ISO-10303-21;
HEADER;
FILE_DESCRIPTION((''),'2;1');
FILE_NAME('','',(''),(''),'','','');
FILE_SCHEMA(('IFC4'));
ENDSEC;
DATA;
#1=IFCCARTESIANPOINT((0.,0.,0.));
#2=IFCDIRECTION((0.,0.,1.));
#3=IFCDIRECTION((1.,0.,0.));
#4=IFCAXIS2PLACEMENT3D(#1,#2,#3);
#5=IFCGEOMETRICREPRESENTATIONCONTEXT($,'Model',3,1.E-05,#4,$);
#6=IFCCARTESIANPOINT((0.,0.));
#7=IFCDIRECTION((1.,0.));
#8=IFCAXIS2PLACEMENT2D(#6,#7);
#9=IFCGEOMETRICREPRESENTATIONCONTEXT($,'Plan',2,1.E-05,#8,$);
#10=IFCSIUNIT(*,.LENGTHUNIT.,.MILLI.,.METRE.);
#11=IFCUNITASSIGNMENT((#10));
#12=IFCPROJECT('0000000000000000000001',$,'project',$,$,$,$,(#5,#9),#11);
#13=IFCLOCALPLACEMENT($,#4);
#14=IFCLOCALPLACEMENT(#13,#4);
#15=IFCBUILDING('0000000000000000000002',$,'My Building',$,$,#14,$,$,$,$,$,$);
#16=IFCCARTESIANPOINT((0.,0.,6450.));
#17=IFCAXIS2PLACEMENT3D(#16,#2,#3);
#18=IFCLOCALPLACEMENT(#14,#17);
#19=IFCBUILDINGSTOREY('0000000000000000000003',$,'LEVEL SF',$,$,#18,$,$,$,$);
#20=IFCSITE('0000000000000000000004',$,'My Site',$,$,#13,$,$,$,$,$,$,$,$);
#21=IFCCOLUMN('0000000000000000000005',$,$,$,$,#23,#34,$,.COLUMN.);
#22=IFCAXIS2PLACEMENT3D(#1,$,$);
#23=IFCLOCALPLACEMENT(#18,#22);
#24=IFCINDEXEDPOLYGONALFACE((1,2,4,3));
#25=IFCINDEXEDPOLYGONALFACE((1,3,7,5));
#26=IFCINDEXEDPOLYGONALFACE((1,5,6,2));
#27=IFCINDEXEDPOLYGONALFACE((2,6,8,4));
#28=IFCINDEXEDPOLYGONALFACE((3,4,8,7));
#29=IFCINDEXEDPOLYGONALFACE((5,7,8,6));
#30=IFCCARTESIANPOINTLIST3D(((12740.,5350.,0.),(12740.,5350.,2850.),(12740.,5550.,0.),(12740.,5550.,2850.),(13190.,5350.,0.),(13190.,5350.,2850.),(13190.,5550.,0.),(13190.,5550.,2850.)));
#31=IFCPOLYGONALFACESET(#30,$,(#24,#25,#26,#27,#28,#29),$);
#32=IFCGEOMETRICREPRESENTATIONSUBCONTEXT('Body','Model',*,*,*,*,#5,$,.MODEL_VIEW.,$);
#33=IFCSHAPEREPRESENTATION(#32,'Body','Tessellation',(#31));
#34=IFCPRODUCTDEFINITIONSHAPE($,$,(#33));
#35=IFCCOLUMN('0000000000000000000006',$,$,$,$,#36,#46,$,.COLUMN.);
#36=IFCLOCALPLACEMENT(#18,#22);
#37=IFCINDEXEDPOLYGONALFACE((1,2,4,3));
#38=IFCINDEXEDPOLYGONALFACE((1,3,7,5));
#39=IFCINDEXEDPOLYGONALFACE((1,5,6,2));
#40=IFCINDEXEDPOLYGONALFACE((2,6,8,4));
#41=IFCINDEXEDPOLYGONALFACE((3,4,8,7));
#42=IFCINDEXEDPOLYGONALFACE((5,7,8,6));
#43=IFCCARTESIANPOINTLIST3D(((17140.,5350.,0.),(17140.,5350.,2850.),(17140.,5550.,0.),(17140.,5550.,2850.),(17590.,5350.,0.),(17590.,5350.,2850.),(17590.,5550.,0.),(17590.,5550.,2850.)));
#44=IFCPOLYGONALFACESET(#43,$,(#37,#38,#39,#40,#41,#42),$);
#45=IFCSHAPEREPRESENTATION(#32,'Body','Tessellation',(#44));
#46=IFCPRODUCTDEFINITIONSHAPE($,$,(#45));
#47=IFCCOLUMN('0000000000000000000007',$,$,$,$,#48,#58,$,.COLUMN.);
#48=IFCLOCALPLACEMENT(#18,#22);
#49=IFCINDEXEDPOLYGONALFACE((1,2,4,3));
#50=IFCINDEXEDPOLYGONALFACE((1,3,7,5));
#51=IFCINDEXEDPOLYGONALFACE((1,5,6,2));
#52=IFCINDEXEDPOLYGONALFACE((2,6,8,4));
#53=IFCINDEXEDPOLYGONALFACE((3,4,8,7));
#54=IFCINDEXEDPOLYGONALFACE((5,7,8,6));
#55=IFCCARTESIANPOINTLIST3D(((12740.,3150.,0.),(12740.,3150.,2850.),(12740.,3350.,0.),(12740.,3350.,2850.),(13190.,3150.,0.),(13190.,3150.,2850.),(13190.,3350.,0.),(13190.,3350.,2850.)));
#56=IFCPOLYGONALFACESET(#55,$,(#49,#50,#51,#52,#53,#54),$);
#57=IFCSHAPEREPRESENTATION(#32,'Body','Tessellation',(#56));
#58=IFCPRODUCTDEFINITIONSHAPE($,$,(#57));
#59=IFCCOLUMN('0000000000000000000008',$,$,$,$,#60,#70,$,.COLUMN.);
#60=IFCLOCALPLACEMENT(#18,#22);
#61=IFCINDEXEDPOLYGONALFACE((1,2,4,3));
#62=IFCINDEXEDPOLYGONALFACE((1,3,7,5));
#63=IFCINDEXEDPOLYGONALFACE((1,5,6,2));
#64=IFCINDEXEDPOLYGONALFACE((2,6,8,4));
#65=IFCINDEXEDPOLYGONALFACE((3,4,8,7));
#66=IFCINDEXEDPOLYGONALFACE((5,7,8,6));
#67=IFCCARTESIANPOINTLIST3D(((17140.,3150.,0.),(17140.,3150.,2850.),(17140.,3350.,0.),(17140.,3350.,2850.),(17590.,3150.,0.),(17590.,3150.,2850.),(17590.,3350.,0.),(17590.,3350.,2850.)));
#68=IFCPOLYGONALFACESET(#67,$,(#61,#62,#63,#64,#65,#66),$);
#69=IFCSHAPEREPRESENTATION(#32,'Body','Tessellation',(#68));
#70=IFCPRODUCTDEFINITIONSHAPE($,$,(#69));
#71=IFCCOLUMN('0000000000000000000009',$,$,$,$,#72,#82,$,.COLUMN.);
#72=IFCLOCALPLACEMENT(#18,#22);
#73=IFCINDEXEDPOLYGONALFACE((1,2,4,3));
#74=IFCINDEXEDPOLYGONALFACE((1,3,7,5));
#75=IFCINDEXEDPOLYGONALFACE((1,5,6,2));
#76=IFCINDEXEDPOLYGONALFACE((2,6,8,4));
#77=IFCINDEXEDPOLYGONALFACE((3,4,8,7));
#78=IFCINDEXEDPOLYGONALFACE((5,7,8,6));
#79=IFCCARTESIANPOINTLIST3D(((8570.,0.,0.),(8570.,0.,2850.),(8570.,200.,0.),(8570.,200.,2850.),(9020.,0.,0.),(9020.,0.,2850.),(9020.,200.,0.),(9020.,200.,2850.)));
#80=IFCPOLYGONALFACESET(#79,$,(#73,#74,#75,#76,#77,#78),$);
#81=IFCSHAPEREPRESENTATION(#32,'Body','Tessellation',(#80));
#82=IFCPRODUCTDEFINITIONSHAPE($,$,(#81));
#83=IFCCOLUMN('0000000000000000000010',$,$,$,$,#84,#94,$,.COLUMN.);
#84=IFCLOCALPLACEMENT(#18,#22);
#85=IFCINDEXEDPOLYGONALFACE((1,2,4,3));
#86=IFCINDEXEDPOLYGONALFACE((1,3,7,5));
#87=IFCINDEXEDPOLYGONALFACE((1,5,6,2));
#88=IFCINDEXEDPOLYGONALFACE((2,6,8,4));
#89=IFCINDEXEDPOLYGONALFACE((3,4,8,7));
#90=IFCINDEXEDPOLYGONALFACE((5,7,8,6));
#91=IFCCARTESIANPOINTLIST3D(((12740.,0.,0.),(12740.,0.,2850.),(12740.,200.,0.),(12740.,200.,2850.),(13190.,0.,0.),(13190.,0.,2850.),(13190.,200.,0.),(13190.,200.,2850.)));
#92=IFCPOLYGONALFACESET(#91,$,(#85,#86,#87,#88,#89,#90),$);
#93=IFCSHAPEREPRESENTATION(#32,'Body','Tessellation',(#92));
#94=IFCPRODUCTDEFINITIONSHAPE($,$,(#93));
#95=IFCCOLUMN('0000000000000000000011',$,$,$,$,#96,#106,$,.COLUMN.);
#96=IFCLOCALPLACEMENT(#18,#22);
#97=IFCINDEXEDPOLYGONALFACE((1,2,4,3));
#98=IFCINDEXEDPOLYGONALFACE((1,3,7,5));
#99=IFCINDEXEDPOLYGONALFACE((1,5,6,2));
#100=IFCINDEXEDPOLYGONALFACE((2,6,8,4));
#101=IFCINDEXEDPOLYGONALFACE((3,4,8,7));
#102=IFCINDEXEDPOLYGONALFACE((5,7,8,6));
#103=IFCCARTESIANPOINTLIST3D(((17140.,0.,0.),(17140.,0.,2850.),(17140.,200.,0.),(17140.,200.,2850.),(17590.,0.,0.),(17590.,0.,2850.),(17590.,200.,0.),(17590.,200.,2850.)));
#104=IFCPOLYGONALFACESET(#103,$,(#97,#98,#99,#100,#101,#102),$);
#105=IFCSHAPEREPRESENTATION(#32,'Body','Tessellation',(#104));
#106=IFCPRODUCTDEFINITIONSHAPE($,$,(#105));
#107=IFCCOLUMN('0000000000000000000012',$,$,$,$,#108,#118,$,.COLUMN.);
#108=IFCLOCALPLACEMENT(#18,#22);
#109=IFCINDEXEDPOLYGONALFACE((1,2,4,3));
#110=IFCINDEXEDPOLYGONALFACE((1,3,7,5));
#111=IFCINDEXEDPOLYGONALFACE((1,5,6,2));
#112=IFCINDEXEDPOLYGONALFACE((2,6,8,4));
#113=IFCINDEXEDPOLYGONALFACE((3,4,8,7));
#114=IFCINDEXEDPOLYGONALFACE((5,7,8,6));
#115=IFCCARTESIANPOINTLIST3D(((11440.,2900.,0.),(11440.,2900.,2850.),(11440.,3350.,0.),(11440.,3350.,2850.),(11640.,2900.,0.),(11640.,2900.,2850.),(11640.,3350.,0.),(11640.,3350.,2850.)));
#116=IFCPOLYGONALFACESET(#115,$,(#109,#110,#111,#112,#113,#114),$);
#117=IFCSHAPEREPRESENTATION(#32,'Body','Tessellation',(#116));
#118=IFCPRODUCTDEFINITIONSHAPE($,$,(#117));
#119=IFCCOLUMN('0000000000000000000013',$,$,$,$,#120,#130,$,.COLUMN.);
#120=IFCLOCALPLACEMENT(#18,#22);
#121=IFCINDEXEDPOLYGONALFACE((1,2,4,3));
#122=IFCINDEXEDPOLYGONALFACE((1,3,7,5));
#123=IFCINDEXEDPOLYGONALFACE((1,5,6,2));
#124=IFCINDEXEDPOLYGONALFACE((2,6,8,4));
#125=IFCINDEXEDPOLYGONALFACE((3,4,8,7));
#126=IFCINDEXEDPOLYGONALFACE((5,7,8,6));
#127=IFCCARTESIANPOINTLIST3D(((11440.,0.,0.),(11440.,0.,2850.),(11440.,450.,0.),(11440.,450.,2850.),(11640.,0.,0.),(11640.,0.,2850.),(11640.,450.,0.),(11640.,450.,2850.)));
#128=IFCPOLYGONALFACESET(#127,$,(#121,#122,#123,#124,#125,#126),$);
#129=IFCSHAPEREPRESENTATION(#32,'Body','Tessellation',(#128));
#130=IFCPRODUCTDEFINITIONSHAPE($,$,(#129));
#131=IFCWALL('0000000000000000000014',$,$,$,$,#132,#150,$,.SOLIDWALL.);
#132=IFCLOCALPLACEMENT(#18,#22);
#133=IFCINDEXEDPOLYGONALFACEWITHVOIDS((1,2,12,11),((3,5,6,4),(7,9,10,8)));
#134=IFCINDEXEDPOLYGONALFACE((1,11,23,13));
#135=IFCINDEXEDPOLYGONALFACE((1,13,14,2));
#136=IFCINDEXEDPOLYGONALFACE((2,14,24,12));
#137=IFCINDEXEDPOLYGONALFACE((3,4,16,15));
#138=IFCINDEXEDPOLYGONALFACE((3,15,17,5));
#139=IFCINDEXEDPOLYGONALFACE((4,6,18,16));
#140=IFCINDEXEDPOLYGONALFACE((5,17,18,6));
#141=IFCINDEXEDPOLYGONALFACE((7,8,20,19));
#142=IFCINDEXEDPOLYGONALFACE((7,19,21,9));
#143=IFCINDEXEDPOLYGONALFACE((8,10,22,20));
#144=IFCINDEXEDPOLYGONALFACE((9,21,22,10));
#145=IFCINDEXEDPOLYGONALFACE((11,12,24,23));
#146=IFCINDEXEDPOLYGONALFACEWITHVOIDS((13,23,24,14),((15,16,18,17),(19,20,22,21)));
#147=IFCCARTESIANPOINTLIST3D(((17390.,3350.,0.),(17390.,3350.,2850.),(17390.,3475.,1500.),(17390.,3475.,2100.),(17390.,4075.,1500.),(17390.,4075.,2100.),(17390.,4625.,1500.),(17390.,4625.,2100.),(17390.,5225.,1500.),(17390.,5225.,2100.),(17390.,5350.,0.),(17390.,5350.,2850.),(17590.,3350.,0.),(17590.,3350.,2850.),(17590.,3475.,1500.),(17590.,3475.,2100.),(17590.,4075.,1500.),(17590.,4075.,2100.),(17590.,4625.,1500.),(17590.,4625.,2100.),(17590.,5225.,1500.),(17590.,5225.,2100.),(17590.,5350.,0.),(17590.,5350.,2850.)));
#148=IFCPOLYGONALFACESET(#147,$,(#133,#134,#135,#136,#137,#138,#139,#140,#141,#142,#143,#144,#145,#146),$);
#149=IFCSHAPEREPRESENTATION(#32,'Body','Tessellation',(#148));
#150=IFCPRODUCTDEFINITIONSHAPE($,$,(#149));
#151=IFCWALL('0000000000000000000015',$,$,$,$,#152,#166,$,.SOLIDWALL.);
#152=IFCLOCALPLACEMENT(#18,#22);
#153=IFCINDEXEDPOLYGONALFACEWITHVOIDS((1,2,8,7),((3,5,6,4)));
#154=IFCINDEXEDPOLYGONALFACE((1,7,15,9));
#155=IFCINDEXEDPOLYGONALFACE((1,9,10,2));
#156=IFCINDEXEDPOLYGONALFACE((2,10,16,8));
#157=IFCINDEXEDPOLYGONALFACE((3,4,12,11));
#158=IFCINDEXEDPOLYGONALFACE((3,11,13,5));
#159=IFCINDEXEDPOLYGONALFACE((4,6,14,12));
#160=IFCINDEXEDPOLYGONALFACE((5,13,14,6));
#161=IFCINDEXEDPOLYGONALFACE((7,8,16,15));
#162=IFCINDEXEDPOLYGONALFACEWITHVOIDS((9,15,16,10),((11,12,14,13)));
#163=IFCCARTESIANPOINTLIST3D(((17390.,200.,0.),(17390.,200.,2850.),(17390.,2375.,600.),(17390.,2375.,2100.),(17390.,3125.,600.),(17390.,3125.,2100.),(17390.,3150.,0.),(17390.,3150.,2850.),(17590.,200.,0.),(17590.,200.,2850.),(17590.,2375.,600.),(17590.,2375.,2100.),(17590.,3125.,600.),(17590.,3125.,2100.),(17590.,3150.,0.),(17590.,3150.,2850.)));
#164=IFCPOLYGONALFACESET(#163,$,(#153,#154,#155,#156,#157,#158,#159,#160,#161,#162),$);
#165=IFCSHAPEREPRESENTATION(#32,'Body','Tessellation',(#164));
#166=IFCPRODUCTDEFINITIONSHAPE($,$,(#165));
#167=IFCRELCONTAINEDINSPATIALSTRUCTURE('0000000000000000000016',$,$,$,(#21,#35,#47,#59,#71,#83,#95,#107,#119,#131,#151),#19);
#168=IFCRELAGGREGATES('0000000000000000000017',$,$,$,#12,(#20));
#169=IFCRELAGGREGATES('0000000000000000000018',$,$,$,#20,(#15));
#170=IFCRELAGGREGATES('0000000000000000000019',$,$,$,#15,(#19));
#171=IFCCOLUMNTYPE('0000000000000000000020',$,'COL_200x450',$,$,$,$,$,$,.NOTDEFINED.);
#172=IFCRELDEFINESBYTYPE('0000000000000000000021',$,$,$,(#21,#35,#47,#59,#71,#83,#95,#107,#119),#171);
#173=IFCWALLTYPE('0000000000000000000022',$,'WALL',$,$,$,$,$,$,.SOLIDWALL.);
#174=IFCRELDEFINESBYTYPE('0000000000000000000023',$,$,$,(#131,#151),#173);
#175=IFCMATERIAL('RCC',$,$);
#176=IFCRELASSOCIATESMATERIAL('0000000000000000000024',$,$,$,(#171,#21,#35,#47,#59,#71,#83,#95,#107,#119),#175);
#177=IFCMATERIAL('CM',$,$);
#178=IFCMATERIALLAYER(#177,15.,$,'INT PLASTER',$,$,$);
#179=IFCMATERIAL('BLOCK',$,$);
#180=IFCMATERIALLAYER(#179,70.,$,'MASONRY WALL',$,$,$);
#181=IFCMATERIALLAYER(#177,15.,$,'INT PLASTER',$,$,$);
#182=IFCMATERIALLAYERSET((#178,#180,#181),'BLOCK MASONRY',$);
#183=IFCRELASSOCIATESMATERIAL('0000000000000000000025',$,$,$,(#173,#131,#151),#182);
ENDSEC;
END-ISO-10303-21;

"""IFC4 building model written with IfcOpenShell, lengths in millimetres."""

from ifc_helpers import new_model, si_unit, frame, origin_with_axes, origin_2d_with_axis, place, context, subcontext, project, spatial, indexed_curve, rectangle, outline, extrude, material, layer, layer_set, layer_usage, material_profile, profile_set, profile_usage, type_object, element, save


model = new_model("IFC4")

# Units and contexts
model_context = context("Model", 3, precision=1e-05, world=origin_with_axes())
plan_context = context("Plan", 2, precision=1e-05, world=origin_2d_with_axis())
body_context = subcontext(model_context, "Body", "Model", "MODEL_VIEW")
ifc_project = project(units=[si_unit("LENGTHUNIT", "METRE", prefix="MILLI")], contexts=[model_context, plan_context])

# Site, building, storey
site_placement = place(None, origin_with_axes())
site = spatial("IfcSite", under=ifc_project, at=site_placement, Name="My Site")
building_placement = place(site_placement, origin_with_axes())
building = spatial("IfcBuilding", under=site, at=building_placement, Name="My Building")
storey_placement = place(building_placement, frame((0.0, 0.0, 6450.0), z_axis=(0.0, 0.0, 1.0), x_axis=(1.0, 0.0, 0.0)))
storey = spatial("IfcBuildingStorey", under=building, at=storey_placement, Name="LEVEL SF")

# Columns
ifc_material_1 = material(Name="RCC")
ifc_material_profile = material_profile(ifc_material_1, rectangle(XDim=200.0, YDim=450.0))
ifc_profile_set = profile_set([ifc_material_profile], Name="COL_200x450")
ifc_profile_usage_1 = profile_usage(ifc_profile_set)
column_type = type_object("IfcColumnType", Name="COL_200x450", PredefinedType="NOTDEFINED", material=ifc_profile_set)
column_1_placement = place(storey_placement, frame((12965.0, 5450.0, 0.0), z_axis=(0.0, 0.0, 1.0), x_axis=(0.0, -1.0, 0.0)))
element("IfcColumn", 1, at=column_1_placement, inside=storey, type_object=column_type, material=ifc_profile_usage_1, PredefinedType="COLUMN", context=body_context, shape_type="SweptSolid", body=[
    extrude(rectangle(XDim=200.0, YDim=450.0), origin_with_axes(), (0.0, 0.0, 1.0), 2850.0),
])
ifc_profile_usage_2 = profile_usage(ifc_profile_set)
column_2_placement = place(storey_placement, frame((17365.0, 5450.0, 0.0), z_axis=(0.0, 0.0, 1.0), x_axis=(0.0, -1.0, 0.0)))
element("IfcColumn", 2, at=column_2_placement, inside=storey, type_object=column_type, material=ifc_profile_usage_2, PredefinedType="COLUMN", context=body_context, shape_type="SweptSolid", body=[
    extrude(rectangle(XDim=200.0, YDim=450.0), origin_with_axes(), (0.0, 0.0, 1.0), 2850.0),
])
ifc_profile_usage_3 = profile_usage(ifc_profile_set)
column_3_placement = place(storey_placement, frame((12965.0, 3250.0, 0.0), z_axis=(0.0, 0.0, 1.0), x_axis=(0.0, -1.0, 0.0)))
element("IfcColumn", 3, at=column_3_placement, inside=storey, type_object=column_type, material=ifc_profile_usage_3, PredefinedType="COLUMN", context=body_context, shape_type="SweptSolid", body=[
    extrude(rectangle(XDim=200.0, YDim=450.0), origin_with_axes(), (0.0, 0.0, 1.0), 2850.0),
])
ifc_profile_usage_4 = profile_usage(ifc_profile_set)
column_4_placement = place(storey_placement, frame((17365.0, 3250.0, 0.0), z_axis=(0.0, 0.0, 1.0), x_axis=(0.0, -1.0, 0.0)))
element("IfcColumn", 4, at=column_4_placement, inside=storey, type_object=column_type, material=ifc_profile_usage_4, PredefinedType="COLUMN", context=body_context, shape_type="SweptSolid", body=[
    extrude(rectangle(XDim=200.0, YDim=450.0), origin_with_axes(), (0.0, 0.0, 1.0), 2850.0),
])
ifc_profile_usage_5 = profile_usage(ifc_profile_set)
column_5_placement = place(storey_placement, frame((8795.0, 100.0, 0.0), z_axis=(0.0, 0.0, 1.0), x_axis=(0.0, -1.0, 0.0)))
element("IfcColumn", 5, at=column_5_placement, inside=storey, type_object=column_type, material=ifc_profile_usage_5, PredefinedType="COLUMN", context=body_context, shape_type="SweptSolid", body=[
    extrude(rectangle(XDim=200.0, YDim=450.0), origin_with_axes(), (0.0, 0.0, 1.0), 2850.0),
])
ifc_profile_usage_6 = profile_usage(ifc_profile_set)
column_6_placement = place(storey_placement, frame((12965.0, 100.0, 0.0), z_axis=(0.0, 0.0, 1.0), x_axis=(0.0, -1.0, 0.0)))
element("IfcColumn", 6, at=column_6_placement, inside=storey, type_object=column_type, material=ifc_profile_usage_6, PredefinedType="COLUMN", context=body_context, shape_type="SweptSolid", body=[
    extrude(rectangle(XDim=200.0, YDim=450.0), origin_with_axes(), (0.0, 0.0, 1.0), 2850.0),
])
ifc_profile_usage_7 = profile_usage(ifc_profile_set)
column_7_placement = place(storey_placement, frame((17365.0, 100.0, 0.0), z_axis=(0.0, 0.0, 1.0), x_axis=(0.0, -1.0, 0.0)))
element("IfcColumn", 7, at=column_7_placement, inside=storey, type_object=column_type, material=ifc_profile_usage_7, PredefinedType="COLUMN", context=body_context, shape_type="SweptSolid", body=[
    extrude(rectangle(XDim=200.0, YDim=450.0), origin_with_axes(), (0.0, 0.0, 1.0), 2850.0),
])
ifc_profile_usage_8 = profile_usage(ifc_profile_set)
column_8_placement = place(storey_placement, frame((11540.0, 3125.0, 0.0), z_axis=(0.0, 0.0, 1.0), x_axis=(1.0, 0.0, 0.0)))
element("IfcColumn", 8, at=column_8_placement, inside=storey, type_object=column_type, material=ifc_profile_usage_8, PredefinedType="COLUMN", context=body_context, shape_type="SweptSolid", body=[
    extrude(rectangle(XDim=200.0, YDim=450.0), origin_with_axes(), (0.0, 0.0, 1.0), 2850.0),
])
ifc_profile_usage_9 = profile_usage(ifc_profile_set)
column_9_placement = place(storey_placement, frame((11540.0, 225.0, 0.0), z_axis=(0.0, 0.0, 1.0), x_axis=(1.0, 0.0, 0.0)))
element("IfcColumn", 9, at=column_9_placement, inside=storey, type_object=column_type, material=ifc_profile_usage_9, PredefinedType="COLUMN", context=body_context, shape_type="SweptSolid", body=[
    extrude(rectangle(XDim=200.0, YDim=450.0), origin_with_axes(), (0.0, 0.0, 1.0), 2850.0),
])

# Wall, openings
ifc_material_2 = material(Name="CM")
ifc_layer_1 = layer(ifc_material_2, 15.0, Name="INT PLASTER")
ifc_material_3 = material(Name="BLOCK")
ifc_layer_2 = layer(ifc_material_3, 70.0, Name="MASONRY WALL")
ifc_layer_3 = layer(ifc_material_2, 15.0, Name="INT PLASTER")
ifc_layer_set = layer_set([ifc_layer_1, ifc_layer_2, ifc_layer_3], Name="BLOCK MASONRY")
ifc_layer_usage_1 = layer_usage(ifc_layer_set, "AXIS2", "POSITIVE", 0.0)
wall_type = type_object("IfcWallType", Name="WALL", PredefinedType="SOLIDWALL", material=ifc_layer_set)
wall_1_placement = place(storey_placement, frame((17590.0, 3350.0, 0.0), z_axis=(0.0, 0.0, 1.0), x_axis=(0.0, 1.0, 0.0)))
wall_1 = element("IfcWall", 10, at=wall_1_placement, inside=storey, type_object=wall_type, material=ifc_layer_usage_1, PredefinedType="SOLIDWALL", context=body_context, shape_type="SweptSolid", body=[
    extrude(outline(indexed_curve([(0.0, 0.0), (0.0, 200.0), (2000.0, 200.0), (2000.0, 0.0), (0.0, 0.0)], self_intersect=False)), origin_with_axes(), (0.0, 0.0, 1.0), 2850.0),
])
opening_1_placement = place(wall_1_placement, frame((1875.0, 200.0, 1500.0), z_axis=(0.0, 0.0, 1.0), x_axis=(-1.0, 0.0, 0.0)))
element("IfcOpeningElement", 11, at=opening_1_placement, cuts=wall_1, PredefinedType="OPENING", context=body_context, shape_type="SweptSolid", body=[
    extrude(outline(indexed_curve([(0.0, 0.0), (0.0, 400.0), (600.0, 400.0), (600.0, 0.0), (0.0, 0.0)], self_intersect=False)), frame((0.0, -100.0, 0.0), z_axis=(0.0, 0.0, 1.0), x_axis=(1.0, 0.0, 0.0)), (0.0, 0.0, 1.0), 600.0),
])
opening_2_placement = place(wall_1_placement, frame((725.0, 200.0, 1500.0), z_axis=(0.0, 0.0, 1.0), x_axis=(-1.0, 0.0, 0.0)))
element("IfcOpeningElement", 12, at=opening_2_placement, cuts=wall_1, PredefinedType="OPENING", context=body_context, shape_type="SweptSolid", body=[
    extrude(outline(indexed_curve([(0.0, 0.0), (0.0, 400.0), (600.0, 400.0), (600.0, 0.0), (0.0, 0.0)], self_intersect=False)), frame((0.0, -100.0, 0.0), z_axis=(0.0, 0.0, 1.0), x_axis=(1.0, 0.0, 0.0)), (0.0, 0.0, 1.0), 600.0),
])

# Wall, opening
ifc_layer_usage_2 = layer_usage(ifc_layer_set, "AXIS2", "POSITIVE", 0.0)
wall_2_placement = place(storey_placement, frame((17590.0, 200.0, 0.0), z_axis=(0.0, 0.0, 1.0), x_axis=(0.0, 1.0, 0.0)))
wall_2 = element("IfcWall", 13, at=wall_2_placement, inside=storey, type_object=wall_type, material=ifc_layer_usage_2, PredefinedType="SOLIDWALL", context=body_context, shape_type="SweptSolid", body=[
    extrude(outline(indexed_curve([(0.0, 0.0), (0.0, 200.0), (2950.0, 200.0), (2950.0, 0.0), (0.0, 0.0)], self_intersect=False)), origin_with_axes(), (0.0, 0.0, 1.0), 2850.0),
])
opening_3_placement = place(wall_2_placement, frame((2925.0, 200.0, 600.0), z_axis=(0.0, 0.0, 1.0), x_axis=(-1.0, 0.0, 0.0)))
element("IfcOpeningElement", 14, at=opening_3_placement, cuts=wall_2, PredefinedType="OPENING", context=body_context, shape_type="SweptSolid", body=[
    extrude(outline(indexed_curve([(0.0, 0.0), (0.0, 400.0), (750.0, 400.0), (750.0, 0.0), (0.0, 0.0)], self_intersect=False)), frame((0.0, -100.0, 0.0), z_axis=(0.0, 0.0, 1.0), x_axis=(1.0, 0.0, 0.0)), (0.0, 0.0, 1.0), 1500.0),
])

save(model, "model.ifc")
